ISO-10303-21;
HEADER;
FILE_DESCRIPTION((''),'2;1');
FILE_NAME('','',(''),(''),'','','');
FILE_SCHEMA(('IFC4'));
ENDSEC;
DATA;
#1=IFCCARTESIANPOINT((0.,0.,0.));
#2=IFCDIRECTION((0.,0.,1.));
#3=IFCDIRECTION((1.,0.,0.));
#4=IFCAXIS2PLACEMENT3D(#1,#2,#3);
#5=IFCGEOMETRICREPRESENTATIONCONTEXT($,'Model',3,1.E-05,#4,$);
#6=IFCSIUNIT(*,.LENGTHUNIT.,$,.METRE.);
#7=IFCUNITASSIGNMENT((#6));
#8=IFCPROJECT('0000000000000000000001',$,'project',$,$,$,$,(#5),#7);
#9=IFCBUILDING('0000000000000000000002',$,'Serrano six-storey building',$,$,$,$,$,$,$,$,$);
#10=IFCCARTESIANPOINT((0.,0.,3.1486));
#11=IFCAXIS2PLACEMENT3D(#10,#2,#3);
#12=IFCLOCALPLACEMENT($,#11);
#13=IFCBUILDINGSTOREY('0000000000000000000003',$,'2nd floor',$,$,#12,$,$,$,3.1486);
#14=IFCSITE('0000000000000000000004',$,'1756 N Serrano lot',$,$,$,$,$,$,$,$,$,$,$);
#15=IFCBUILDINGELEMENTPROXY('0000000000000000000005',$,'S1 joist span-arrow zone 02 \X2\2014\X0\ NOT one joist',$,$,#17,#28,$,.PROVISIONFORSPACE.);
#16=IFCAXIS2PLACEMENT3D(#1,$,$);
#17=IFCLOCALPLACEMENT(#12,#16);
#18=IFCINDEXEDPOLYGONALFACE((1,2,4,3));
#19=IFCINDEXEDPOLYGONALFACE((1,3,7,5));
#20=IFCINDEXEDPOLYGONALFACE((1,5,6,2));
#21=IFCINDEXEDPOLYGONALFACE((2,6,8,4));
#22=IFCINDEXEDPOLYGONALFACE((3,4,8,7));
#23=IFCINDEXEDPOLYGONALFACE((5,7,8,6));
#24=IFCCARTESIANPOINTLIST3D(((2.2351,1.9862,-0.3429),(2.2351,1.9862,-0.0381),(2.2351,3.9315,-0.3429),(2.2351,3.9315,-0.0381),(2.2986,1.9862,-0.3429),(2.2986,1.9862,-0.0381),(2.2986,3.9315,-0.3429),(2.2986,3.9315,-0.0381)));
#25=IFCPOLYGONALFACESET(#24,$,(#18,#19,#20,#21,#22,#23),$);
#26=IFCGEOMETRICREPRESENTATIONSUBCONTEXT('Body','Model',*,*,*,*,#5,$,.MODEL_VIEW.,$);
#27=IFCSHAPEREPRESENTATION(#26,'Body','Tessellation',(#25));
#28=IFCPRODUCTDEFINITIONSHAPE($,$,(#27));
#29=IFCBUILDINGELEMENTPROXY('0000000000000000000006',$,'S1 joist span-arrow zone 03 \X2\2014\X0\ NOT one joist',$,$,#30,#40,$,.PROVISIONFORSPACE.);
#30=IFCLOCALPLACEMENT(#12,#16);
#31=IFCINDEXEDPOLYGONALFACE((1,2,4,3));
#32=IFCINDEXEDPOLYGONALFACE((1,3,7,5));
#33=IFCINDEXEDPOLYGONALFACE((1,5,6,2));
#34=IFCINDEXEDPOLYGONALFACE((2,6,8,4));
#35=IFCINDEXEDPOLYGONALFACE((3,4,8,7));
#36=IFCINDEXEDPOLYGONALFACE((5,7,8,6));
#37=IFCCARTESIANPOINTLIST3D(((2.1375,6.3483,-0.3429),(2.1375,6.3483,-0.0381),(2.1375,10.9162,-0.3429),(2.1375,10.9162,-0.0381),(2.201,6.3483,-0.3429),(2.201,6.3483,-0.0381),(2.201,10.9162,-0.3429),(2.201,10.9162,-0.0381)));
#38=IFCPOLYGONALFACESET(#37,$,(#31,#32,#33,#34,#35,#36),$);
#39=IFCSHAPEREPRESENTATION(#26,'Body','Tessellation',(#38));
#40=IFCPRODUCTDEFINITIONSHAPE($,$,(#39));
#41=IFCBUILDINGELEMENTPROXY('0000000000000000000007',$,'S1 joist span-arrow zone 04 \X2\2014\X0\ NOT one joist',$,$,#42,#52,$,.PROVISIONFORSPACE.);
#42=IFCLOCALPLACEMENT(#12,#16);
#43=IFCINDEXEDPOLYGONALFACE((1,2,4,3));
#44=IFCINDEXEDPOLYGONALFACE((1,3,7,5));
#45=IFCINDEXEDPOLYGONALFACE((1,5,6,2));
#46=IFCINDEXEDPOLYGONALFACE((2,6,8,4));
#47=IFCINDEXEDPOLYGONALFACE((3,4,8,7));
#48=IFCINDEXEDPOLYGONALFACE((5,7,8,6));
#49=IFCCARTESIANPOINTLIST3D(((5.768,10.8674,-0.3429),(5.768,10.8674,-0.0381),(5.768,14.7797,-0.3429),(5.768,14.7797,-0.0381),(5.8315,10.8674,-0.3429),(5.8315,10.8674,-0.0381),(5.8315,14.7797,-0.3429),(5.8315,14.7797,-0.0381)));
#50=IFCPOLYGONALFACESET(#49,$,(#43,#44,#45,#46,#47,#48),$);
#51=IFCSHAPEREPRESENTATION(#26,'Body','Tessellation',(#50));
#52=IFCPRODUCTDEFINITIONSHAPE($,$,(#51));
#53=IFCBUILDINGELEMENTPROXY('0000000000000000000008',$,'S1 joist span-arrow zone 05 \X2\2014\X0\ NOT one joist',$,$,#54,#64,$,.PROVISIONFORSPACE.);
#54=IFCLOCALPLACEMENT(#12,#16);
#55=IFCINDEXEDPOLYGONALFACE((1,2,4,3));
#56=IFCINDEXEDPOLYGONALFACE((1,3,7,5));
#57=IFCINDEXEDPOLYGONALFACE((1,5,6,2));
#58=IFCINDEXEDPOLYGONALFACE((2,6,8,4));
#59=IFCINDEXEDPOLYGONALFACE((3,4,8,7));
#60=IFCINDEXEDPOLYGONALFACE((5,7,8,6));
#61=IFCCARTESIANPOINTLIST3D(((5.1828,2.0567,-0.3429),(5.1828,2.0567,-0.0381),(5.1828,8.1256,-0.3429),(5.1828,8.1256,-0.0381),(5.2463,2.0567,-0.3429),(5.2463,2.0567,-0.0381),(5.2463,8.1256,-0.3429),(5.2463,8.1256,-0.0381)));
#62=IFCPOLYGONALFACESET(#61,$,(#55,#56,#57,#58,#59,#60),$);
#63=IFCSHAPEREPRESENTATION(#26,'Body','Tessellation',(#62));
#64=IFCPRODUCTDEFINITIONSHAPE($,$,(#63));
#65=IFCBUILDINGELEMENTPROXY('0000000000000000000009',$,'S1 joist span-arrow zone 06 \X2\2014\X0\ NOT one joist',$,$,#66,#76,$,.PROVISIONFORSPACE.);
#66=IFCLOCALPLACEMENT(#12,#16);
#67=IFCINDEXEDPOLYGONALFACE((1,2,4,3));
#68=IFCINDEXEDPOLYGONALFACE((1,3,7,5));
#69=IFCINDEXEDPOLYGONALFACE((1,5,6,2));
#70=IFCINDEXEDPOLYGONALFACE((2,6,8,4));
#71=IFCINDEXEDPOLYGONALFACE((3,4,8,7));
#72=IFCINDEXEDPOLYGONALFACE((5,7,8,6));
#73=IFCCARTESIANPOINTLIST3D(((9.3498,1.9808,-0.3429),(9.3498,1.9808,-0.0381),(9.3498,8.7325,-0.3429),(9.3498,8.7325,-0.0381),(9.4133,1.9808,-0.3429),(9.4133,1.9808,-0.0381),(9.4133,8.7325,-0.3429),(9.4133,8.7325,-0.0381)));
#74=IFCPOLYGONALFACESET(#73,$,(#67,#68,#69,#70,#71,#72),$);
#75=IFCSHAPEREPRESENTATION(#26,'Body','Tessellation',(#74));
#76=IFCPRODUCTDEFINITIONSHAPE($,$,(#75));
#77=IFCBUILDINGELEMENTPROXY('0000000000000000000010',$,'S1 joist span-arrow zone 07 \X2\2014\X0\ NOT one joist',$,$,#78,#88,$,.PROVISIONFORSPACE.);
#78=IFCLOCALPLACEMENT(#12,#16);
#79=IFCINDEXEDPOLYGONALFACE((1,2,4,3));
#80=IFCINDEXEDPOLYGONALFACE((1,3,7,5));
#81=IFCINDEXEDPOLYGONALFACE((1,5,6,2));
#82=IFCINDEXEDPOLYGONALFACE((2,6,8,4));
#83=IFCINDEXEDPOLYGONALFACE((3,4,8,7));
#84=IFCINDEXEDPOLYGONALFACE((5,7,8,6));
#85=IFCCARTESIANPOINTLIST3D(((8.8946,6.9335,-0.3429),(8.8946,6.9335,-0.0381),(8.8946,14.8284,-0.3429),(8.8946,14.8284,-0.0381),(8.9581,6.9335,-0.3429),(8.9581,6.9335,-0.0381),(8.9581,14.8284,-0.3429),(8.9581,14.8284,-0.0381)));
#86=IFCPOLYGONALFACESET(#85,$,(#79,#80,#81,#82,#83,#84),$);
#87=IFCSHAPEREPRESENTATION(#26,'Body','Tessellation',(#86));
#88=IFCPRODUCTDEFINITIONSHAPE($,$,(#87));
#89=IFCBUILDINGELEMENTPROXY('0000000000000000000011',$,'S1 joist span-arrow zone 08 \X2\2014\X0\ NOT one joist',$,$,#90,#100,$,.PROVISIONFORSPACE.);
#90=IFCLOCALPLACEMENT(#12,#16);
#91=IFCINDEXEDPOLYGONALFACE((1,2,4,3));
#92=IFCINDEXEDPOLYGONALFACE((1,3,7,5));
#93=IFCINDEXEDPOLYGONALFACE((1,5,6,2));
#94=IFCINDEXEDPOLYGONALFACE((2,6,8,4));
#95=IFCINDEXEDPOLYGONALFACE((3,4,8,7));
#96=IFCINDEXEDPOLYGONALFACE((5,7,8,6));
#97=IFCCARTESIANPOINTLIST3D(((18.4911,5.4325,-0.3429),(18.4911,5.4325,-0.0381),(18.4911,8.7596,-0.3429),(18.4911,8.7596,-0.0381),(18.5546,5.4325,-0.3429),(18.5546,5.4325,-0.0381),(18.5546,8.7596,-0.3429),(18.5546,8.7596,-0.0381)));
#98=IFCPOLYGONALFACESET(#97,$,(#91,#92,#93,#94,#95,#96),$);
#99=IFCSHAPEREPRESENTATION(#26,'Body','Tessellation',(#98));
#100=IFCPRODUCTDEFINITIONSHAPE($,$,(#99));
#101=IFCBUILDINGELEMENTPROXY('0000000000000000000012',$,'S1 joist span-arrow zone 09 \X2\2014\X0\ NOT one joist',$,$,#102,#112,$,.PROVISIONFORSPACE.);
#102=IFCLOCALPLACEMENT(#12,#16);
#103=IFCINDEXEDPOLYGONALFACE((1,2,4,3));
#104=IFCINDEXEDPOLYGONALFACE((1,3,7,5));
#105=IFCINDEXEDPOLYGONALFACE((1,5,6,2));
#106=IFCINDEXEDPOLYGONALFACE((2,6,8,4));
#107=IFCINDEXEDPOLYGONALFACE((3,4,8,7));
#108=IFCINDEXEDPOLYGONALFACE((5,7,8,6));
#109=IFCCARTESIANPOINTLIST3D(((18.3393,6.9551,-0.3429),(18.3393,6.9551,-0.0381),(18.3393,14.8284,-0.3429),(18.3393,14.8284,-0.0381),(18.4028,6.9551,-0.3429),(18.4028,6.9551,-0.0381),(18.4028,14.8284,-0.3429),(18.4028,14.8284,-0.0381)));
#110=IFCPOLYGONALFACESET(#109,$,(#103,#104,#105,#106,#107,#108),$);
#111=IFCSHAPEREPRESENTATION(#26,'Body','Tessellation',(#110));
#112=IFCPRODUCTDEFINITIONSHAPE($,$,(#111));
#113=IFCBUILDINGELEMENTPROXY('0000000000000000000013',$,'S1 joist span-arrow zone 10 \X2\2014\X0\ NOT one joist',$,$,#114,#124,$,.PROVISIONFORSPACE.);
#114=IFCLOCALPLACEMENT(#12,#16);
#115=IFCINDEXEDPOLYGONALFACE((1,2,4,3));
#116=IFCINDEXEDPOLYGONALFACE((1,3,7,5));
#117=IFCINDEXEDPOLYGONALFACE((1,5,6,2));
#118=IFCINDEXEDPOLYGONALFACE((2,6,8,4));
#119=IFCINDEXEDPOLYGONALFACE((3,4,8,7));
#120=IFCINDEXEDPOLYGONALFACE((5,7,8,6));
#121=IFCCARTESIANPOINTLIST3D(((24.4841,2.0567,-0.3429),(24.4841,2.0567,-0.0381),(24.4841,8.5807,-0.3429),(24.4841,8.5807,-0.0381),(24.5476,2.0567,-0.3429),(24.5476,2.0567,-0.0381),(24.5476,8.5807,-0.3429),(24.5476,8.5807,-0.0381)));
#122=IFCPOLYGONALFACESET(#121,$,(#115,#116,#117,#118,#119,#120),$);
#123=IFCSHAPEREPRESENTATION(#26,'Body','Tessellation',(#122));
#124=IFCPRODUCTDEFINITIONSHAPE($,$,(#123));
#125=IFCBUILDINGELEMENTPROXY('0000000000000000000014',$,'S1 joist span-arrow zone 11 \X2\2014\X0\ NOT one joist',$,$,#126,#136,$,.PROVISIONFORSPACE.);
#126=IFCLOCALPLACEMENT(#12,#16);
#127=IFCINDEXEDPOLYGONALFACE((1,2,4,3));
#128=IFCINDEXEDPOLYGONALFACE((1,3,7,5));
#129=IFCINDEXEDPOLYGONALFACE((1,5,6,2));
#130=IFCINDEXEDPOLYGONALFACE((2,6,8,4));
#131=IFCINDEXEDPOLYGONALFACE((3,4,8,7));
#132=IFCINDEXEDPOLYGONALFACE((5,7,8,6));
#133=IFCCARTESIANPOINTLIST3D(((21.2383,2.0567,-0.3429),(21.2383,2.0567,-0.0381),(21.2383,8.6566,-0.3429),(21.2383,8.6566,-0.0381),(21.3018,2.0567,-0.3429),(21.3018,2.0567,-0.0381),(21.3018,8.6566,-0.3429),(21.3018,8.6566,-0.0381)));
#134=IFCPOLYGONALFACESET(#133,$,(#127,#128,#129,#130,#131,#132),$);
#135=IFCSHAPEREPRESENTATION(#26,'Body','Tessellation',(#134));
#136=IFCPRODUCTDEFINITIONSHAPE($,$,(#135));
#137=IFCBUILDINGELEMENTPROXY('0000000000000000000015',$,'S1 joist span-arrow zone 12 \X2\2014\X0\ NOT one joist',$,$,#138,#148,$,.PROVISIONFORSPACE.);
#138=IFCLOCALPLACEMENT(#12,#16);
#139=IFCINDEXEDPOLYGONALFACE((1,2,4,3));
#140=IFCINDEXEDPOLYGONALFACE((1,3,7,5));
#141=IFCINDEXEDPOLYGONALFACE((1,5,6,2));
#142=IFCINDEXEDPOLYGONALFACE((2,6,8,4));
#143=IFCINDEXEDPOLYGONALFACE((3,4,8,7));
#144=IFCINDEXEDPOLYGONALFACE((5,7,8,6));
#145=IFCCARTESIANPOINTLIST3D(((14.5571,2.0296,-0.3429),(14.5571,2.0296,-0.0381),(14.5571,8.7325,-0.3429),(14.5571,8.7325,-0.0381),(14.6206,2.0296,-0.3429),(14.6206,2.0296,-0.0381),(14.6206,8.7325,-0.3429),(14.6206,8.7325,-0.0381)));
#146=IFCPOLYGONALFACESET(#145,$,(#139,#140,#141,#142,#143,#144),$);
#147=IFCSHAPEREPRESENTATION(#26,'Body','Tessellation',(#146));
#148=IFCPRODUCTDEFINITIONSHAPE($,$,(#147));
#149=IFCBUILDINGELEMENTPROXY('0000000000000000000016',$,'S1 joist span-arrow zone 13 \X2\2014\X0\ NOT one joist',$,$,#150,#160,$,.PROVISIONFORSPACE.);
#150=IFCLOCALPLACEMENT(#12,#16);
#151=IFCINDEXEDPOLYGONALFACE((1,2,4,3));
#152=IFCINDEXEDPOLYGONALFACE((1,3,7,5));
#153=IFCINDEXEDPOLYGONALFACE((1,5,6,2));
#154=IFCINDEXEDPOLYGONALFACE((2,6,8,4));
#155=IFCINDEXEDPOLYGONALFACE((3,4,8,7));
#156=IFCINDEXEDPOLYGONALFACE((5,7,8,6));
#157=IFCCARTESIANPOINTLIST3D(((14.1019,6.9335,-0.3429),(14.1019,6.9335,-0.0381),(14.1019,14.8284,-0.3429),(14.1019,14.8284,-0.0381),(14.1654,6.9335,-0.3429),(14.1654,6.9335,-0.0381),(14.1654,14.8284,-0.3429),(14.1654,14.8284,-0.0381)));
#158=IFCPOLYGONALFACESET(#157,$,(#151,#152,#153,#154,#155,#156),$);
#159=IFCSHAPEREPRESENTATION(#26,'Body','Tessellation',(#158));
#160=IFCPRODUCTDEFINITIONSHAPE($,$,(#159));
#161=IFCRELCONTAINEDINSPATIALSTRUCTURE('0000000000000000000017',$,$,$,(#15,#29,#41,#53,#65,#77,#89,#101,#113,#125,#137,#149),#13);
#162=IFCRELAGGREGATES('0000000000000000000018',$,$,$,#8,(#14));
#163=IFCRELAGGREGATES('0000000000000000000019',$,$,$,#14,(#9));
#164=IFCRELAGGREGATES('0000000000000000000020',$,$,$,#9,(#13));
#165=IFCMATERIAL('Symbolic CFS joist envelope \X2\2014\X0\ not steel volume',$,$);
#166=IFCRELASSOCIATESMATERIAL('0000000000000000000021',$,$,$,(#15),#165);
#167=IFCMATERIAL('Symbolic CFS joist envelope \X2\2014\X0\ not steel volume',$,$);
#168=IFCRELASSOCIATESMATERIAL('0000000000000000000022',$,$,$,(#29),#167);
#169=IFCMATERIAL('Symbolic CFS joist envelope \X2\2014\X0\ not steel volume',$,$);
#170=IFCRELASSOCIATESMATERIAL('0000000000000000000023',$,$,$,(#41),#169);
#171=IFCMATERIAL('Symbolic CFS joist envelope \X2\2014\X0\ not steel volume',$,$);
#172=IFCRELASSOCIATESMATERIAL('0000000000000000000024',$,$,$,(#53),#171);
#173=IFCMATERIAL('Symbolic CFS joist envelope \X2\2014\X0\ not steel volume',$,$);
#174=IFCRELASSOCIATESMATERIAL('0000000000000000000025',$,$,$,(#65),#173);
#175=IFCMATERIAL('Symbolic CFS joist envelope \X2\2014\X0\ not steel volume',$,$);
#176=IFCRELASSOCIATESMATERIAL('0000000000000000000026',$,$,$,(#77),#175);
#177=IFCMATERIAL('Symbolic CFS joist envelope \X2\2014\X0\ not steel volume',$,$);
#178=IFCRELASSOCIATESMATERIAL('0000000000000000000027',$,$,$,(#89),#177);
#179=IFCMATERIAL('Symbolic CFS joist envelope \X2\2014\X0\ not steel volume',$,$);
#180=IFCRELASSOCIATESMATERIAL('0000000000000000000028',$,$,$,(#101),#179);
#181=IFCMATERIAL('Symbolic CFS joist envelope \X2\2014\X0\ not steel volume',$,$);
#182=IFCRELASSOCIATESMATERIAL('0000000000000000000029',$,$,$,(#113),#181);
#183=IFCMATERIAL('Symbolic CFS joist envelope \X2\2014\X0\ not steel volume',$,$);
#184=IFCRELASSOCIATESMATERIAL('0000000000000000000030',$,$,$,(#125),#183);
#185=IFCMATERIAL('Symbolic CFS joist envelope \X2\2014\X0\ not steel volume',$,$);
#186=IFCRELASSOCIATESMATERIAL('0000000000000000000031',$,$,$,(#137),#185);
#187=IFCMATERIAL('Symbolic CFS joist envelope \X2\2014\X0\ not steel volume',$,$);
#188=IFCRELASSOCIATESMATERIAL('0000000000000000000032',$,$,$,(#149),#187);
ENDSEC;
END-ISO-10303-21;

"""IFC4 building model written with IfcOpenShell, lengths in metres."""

from ifc_helpers import new_model, si_unit, frame, origin_with_axes, place, context, subcontext, project, spatial, polyline, outline, extrude, material, element, save


model = new_model("IFC4")

# Units and contexts
model_context = context("Model", 3, precision=1e-05, world=origin_with_axes())
body_context = subcontext(model_context, "Body", "Model", "MODEL_VIEW")
ifc_project = project(units=[si_unit("LENGTHUNIT", "METRE")], contexts=[model_context])

# Site, building, storey
site = spatial("IfcSite", under=ifc_project, Name="1756 N Serrano lot")
building = spatial("IfcBuilding", under=site, Name="Serrano six-storey building")
storey_placement = place(None, frame((0.0, 0.0, 3.1486), z_axis=(0.0, 0.0, 1.0), x_axis=(1.0, 0.0, 0.0)))
storey = spatial("IfcBuildingStorey", under=building, at=storey_placement, Name="2nd floor", Elevation=3.1486)

# Building element proxies
ifc_material_1 = material(Name="Symbolic CFS joist envelope — not steel volume")
proxy_1_placement = place(storey_placement, frame((0.0, 0.0, -3.1486), z_axis=(0.0, 0.0, 1.0), x_axis=(1.0, 0.0, 0.0)))
element("IfcBuildingElementProxy", 1, at=proxy_1_placement, inside=storey, material=ifc_material_1, Name="S1 joist span-arrow zone 02 — NOT one joist", PredefinedType="PROVISIONFORSPACE", context=body_context, shape_type="SweptSolid", body=[
    extrude(outline(polyline([(2.2351, 3.9315), (2.2986, 3.9315), (2.2986, 1.9862), (2.2351, 1.9862), (2.2351, 3.9315)])), frame((0.0, 0.0, 2.8057)), (0.0, 0.0, 1.0), 0.3048),
])
ifc_material_2 = material(Name="Symbolic CFS joist envelope — not steel volume")
proxy_2_placement = place(storey_placement, frame((0.0, 0.0, -3.1486), z_axis=(0.0, 0.0, 1.0), x_axis=(1.0, 0.0, 0.0)))
element("IfcBuildingElementProxy", 2, at=proxy_2_placement, inside=storey, material=ifc_material_2, Name="S1 joist span-arrow zone 03 — NOT one joist", PredefinedType="PROVISIONFORSPACE", context=body_context, shape_type="SweptSolid", body=[
    extrude(outline(polyline([(2.1375, 10.9162), (2.201, 10.9162), (2.201, 6.3483), (2.1375, 6.3483), (2.1375, 10.9162)])), frame((0.0, 0.0, 2.8057)), (0.0, 0.0, 1.0), 0.3048),
])
ifc_material_3 = material(Name="Symbolic CFS joist envelope — not steel volume")
proxy_3_placement = place(storey_placement, frame((0.0, 0.0, -3.1486), z_axis=(0.0, 0.0, 1.0), x_axis=(1.0, 0.0, 0.0)))
element("IfcBuildingElementProxy", 3, at=proxy_3_placement, inside=storey, material=ifc_material_3, Name="S1 joist span-arrow zone 04 — NOT one joist", PredefinedType="PROVISIONFORSPACE", context=body_context, shape_type="SweptSolid", body=[
    extrude(outline(polyline([(5.768, 14.7797), (5.8315, 14.7797), (5.8315, 10.8674), (5.768, 10.8674), (5.768, 14.7797)])), frame((0.0, 0.0, 2.8057)), (0.0, 0.0, 1.0), 0.3048),
])
ifc_material_4 = material(Name="Symbolic CFS joist envelope — not steel volume")
proxy_4_placement = place(storey_placement, frame((0.0, 0.0, -3.1486), z_axis=(0.0, 0.0, 1.0), x_axis=(1.0, 0.0, 0.0)))
element("IfcBuildingElementProxy", 4, at=proxy_4_placement, inside=storey, material=ifc_material_4, Name="S1 joist span-arrow zone 05 — NOT one joist", PredefinedType="PROVISIONFORSPACE", context=body_context, shape_type="SweptSolid", body=[
    extrude(outline(polyline([(5.1828, 8.1256), (5.2463, 8.1256), (5.2463, 2.0567), (5.1828, 2.0567), (5.1828, 8.1256)])), frame((0.0, 0.0, 2.8057)), (0.0, 0.0, 1.0), 0.3048),
])
ifc_material_5 = material(Name="Symbolic CFS joist envelope — not steel volume")
proxy_5_placement = place(storey_placement, frame((0.0, 0.0, -3.1486), z_axis=(0.0, 0.0, 1.0), x_axis=(1.0, 0.0, 0.0)))
element("IfcBuildingElementProxy", 5, at=proxy_5_placement, inside=storey, material=ifc_material_5, Name="S1 joist span-arrow zone 06 — NOT one joist", PredefinedType="PROVISIONFORSPACE", context=body_context, shape_type="SweptSolid", body=[
    extrude(outline(polyline([(9.3498, 8.7325), (9.4133, 8.7325), (9.4133, 1.9808), (9.3498, 1.9808), (9.3498, 8.7325)])), frame((0.0, 0.0, 2.8057)), (0.0, 0.0, 1.0), 0.3048),
])
ifc_material_6 = material(Name="Symbolic CFS joist envelope — not steel volume")
proxy_6_placement = place(storey_placement, frame((0.0, 0.0, -3.1486), z_axis=(0.0, 0.0, 1.0), x_axis=(1.0, 0.0, 0.0)))
element("IfcBuildingElementProxy", 6, at=proxy_6_placement, inside=storey, material=ifc_material_6, Name="S1 joist span-arrow zone 07 — NOT one joist", PredefinedType="PROVISIONFORSPACE", context=body_context, shape_type="SweptSolid", body=[
    extrude(outline(polyline([(8.8946, 14.8284), (8.9581, 14.8284), (8.9581, 6.9335), (8.8946, 6.9335), (8.8946, 14.8284)])), frame((0.0, 0.0, 2.8057)), (0.0, 0.0, 1.0), 0.3048),
])
ifc_material_7 = material(Name="Symbolic CFS joist envelope — not steel volume")
proxy_7_placement = place(storey_placement, frame((0.0, 0.0, -3.1486), z_axis=(0.0, 0.0, 1.0), x_axis=(1.0, 0.0, 0.0)))
element("IfcBuildingElementProxy", 7, at=proxy_7_placement, inside=storey, material=ifc_material_7, Name="S1 joist span-arrow zone 08 — NOT one joist", PredefinedType="PROVISIONFORSPACE", context=body_context, shape_type="SweptSolid", body=[
    extrude(outline(polyline([(18.4911, 8.7596), (18.5546, 8.7596), (18.5546, 5.4325), (18.4911, 5.4325), (18.4911, 8.7596)])), frame((0.0, 0.0, 2.8057)), (0.0, 0.0, 1.0), 0.3048),
])
ifc_material_8 = material(Name="Symbolic CFS joist envelope — not steel volume")
proxy_8_placement = place(storey_placement, frame((0.0, 0.0, -3.1486), z_axis=(0.0, 0.0, 1.0), x_axis=(1.0, 0.0, 0.0)))
element("IfcBuildingElementProxy", 8, at=proxy_8_placement, inside=storey, material=ifc_material_8, Name="S1 joist span-arrow zone 09 — NOT one joist", PredefinedType="PROVISIONFORSPACE", context=body_context, shape_type="SweptSolid", body=[
    extrude(outline(polyline([(18.3393, 14.8284), (18.4028, 14.8284), (18.4028, 6.9551), (18.3393, 6.9551), (18.3393, 14.8284)])), frame((0.0, 0.0, 2.8057)), (0.0, 0.0, 1.0), 0.3048),
])
ifc_material_9 = material(Name="Symbolic CFS joist envelope — not steel volume")
proxy_9_placement = place(storey_placement, frame((0.0, 0.0, -3.1486), z_axis=(0.0, 0.0, 1.0), x_axis=(1.0, 0.0, 0.0)))
element("IfcBuildingElementProxy", 9, at=proxy_9_placement, inside=storey, material=ifc_material_9, Name="S1 joist span-arrow zone 10 — NOT one joist", PredefinedType="PROVISIONFORSPACE", context=body_context, shape_type="SweptSolid", body=[
    extrude(outline(polyline([(24.4841, 8.5807), (24.5476, 8.5807), (24.5476, 2.0567), (24.4841, 2.0567), (24.4841, 8.5807)])), frame((0.0, 0.0, 2.8057)), (0.0, 0.0, 1.0), 0.3048),
])
ifc_material_10 = material(Name="Symbolic CFS joist envelope — not steel volume")
proxy_10_placement = place(storey_placement, frame((0.0, 0.0, -3.1486), z_axis=(0.0, 0.0, 1.0), x_axis=(1.0, 0.0, 0.0)))
element("IfcBuildingElementProxy", 10, at=proxy_10_placement, inside=storey, material=ifc_material_10, Name="S1 joist span-arrow zone 11 — NOT one joist", PredefinedType="PROVISIONFORSPACE", context=body_context, shape_type="SweptSolid", body=[
    extrude(outline(polyline([(21.2383, 8.6566), (21.3018, 8.6566), (21.3018, 2.0567), (21.2383, 2.0567), (21.2383, 8.6566)])), frame((0.0, 0.0, 2.8057)), (0.0, 0.0, 1.0), 0.3048),
])
ifc_material_11 = material(Name="Symbolic CFS joist envelope — not steel volume")
proxy_11_placement = place(storey_placement, frame((0.0, 0.0, -3.1486), z_axis=(0.0, 0.0, 1.0), x_axis=(1.0, 0.0, 0.0)))
element("IfcBuildingElementProxy", 11, at=proxy_11_placement, inside=storey, material=ifc_material_11, Name="S1 joist span-arrow zone 12 — NOT one joist", PredefinedType="PROVISIONFORSPACE", context=body_context, shape_type="SweptSolid", body=[
    extrude(outline(polyline([(14.5571, 8.7325), (14.6206, 8.7325), (14.6206, 2.0296), (14.5571, 2.0296), (14.5571, 8.7325)])), frame((0.0, 0.0, 2.8057)), (0.0, 0.0, 1.0), 0.3048),
])
ifc_material_12 = material(Name="Symbolic CFS joist envelope — not steel volume")
proxy_12_placement = place(storey_placement, frame((0.0, 0.0, -3.1486), z_axis=(0.0, 0.0, 1.0), x_axis=(1.0, 0.0, 0.0)))
element("IfcBuildingElementProxy", 12, at=proxy_12_placement, inside=storey, material=ifc_material_12, Name="S1 joist span-arrow zone 13 — NOT one joist", PredefinedType="PROVISIONFORSPACE", context=body_context, shape_type="SweptSolid", body=[
    extrude(outline(polyline([(14.1019, 14.8284), (14.1654, 14.8284), (14.1654, 6.9335), (14.1019, 6.9335), (14.1019, 14.8284)])), frame((0.0, 0.0, 2.8057)), (0.0, 0.0, 1.0), 0.3048),
])

save(model, "model.ifc")
